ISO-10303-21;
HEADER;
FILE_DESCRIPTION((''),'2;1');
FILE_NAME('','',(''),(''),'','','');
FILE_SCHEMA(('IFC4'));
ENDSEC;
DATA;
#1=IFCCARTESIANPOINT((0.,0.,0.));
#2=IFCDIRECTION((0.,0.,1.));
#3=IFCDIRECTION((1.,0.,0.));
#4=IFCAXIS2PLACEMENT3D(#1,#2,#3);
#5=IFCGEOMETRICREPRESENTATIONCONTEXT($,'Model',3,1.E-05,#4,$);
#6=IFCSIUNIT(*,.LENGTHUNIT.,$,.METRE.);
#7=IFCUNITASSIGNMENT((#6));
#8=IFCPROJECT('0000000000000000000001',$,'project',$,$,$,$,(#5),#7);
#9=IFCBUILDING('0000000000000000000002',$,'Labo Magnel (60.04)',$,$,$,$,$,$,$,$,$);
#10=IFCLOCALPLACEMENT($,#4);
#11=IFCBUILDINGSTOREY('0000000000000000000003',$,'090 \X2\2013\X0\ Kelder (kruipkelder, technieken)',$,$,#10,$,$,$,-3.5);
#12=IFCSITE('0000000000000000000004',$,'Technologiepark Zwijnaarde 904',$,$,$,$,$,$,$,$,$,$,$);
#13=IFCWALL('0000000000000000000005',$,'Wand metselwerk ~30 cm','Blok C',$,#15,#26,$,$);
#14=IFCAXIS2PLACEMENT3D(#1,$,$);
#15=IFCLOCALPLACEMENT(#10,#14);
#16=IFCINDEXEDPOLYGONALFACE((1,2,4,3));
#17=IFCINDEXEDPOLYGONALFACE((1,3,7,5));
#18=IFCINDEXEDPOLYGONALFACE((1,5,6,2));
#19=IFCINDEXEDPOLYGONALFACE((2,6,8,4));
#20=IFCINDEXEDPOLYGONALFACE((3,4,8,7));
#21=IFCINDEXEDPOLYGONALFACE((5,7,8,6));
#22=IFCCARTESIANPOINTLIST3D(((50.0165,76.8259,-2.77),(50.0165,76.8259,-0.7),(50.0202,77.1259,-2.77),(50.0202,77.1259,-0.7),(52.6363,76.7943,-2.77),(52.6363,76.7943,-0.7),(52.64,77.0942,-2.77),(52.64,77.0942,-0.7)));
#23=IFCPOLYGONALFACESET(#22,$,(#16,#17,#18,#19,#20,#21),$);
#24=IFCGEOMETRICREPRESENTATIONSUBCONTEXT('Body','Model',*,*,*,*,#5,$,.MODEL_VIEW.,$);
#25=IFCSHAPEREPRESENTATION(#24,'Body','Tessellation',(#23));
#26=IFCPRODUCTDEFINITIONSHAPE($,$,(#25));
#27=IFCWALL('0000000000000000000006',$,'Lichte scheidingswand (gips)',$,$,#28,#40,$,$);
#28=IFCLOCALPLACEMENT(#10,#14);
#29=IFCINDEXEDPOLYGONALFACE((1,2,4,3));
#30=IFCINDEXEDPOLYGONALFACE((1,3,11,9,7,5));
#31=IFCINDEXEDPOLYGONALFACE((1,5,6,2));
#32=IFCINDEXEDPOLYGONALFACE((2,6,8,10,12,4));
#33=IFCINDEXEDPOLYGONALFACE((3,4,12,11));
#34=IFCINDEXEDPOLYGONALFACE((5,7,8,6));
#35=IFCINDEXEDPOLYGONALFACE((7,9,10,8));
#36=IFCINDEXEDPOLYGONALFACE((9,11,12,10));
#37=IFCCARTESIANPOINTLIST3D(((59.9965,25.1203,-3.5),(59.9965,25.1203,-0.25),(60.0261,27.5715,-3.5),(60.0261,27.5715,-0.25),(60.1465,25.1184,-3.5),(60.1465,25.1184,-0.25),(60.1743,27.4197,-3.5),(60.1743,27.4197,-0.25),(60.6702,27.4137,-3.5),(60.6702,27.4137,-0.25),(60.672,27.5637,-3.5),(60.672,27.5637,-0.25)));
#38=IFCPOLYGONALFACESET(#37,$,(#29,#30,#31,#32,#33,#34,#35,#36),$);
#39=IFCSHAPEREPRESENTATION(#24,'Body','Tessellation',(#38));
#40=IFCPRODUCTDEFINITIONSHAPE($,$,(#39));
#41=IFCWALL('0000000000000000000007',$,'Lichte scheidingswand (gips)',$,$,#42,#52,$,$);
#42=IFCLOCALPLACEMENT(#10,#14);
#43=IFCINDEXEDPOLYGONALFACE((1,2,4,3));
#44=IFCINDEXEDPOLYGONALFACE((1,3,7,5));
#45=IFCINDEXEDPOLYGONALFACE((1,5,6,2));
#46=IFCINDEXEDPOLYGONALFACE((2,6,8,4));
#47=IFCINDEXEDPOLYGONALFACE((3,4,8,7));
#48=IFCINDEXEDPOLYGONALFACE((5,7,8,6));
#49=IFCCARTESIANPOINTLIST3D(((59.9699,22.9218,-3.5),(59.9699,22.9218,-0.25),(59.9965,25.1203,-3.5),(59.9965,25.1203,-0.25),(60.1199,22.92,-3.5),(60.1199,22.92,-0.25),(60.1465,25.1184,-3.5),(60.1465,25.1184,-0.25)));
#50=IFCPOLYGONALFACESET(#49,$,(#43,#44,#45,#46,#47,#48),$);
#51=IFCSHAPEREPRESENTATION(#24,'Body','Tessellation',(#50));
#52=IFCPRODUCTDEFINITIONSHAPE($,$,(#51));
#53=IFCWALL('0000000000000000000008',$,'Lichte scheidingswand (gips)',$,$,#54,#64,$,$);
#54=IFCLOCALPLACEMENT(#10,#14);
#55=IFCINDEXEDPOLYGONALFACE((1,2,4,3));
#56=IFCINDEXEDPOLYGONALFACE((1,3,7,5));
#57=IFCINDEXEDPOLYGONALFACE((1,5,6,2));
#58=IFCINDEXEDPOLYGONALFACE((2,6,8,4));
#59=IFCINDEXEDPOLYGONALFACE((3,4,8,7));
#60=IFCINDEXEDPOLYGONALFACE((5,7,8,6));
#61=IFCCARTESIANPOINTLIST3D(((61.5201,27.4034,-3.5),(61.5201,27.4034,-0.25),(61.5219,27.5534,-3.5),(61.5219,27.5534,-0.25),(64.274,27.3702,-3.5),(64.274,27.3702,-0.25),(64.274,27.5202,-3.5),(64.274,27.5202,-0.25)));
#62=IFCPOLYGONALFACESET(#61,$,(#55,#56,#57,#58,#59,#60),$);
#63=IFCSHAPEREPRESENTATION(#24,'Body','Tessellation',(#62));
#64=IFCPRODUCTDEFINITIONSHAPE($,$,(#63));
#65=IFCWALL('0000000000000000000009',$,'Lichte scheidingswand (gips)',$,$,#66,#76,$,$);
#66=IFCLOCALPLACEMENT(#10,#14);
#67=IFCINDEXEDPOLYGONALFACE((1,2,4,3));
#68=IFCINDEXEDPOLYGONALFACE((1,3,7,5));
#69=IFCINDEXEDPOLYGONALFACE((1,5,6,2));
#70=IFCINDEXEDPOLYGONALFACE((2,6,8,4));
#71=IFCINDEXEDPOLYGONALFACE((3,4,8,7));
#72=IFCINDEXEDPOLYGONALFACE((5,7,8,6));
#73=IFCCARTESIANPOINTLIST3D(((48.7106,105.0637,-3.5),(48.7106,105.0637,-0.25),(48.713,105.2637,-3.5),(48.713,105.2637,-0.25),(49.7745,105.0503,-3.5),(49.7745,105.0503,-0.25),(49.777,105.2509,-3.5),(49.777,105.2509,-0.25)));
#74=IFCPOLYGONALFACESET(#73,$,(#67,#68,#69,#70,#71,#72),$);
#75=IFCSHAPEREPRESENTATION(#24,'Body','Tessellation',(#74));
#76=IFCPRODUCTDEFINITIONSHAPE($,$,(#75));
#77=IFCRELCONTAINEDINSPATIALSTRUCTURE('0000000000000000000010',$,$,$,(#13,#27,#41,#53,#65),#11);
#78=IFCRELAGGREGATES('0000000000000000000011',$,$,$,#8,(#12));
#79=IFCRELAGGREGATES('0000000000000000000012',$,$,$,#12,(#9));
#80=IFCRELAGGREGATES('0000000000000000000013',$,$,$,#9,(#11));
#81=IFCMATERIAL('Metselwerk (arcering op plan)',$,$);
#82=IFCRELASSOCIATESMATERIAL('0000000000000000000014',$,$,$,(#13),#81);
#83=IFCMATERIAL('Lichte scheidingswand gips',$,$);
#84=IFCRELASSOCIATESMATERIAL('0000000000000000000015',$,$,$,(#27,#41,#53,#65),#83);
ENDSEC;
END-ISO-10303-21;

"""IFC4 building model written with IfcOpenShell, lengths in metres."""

from ifc_helpers import new_model, si_unit, frame, origin, origin_with_axes, place, context, subcontext, project, spatial, polyline, outline, extrude, material, element, save


model = new_model("IFC4")

# Units and contexts
model_context = context("Model", 3, precision=1e-05, world=origin_with_axes())
body_context = subcontext(model_context, "Body", "Model", "MODEL_VIEW")
ifc_project = project(units=[si_unit("LENGTHUNIT", "METRE")], contexts=[model_context])

# Site, building, storey
site = spatial("IfcSite", under=ifc_project, Name="Technologiepark Zwijnaarde 904")
building = spatial("IfcBuilding", under=site, Name="Labo Magnel (60.04)")
storey_placement = place(None, origin_with_axes())
storey = spatial("IfcBuildingStorey", under=building, at=storey_placement, Name="090 – Kelder (kruipkelder, technieken)", Elevation=-3.5)

# Shared definitions
ifc_material_1 = material(Name="Metselwerk (arcering op plan)")

# Walls
wall_1_placement = place(storey_placement, frame((0.0, 0.0, -2.77), z_axis=(0.0, 0.0, 1.0), x_axis=(1.0, 0.0, 0.0)))
element("IfcWall", 1, at=wall_1_placement, inside=storey, material=ifc_material_1, Name="Wand metselwerk ~30 cm", Description="Blok C", context=body_context, shape_type="SweptSolid", body=[
    extrude(outline(polyline([(52.64, 77.0942), (50.0202, 77.1259), (50.0165, 76.8259), (52.6363, 76.7943), (52.64, 77.0942)])), origin(), (0.0, 0.0, 1.0), 2.07),
])
ifc_material_2 = material(Name="Lichte scheidingswand gips")
wall_2_placement = place(storey_placement, frame((0.0, 0.0, -3.5), z_axis=(0.0, 0.0, 1.0), x_axis=(1.0, 0.0, 0.0)))
element("IfcWall", 2, at=wall_2_placement, inside=storey, material=ifc_material_2, Name="Lichte scheidingswand (gips)", context=body_context, shape_type="SweptSolid", body=[
    extrude(outline(polyline([(60.672, 27.5637), (60.0261, 27.5715), (59.9965, 25.1203), (60.1465, 25.1184), (60.1743, 27.4197), (60.6702, 27.4137), (60.672, 27.5637)])), origin(), (0.0, 0.0, 1.0), 3.25),
])
wall_3_placement = place(storey_placement, frame((0.0, 0.0, -3.5), z_axis=(0.0, 0.0, 1.0), x_axis=(1.0, 0.0, 0.0)))
element("IfcWall", 3, at=wall_3_placement, inside=storey, material=ifc_material_2, Name="Lichte scheidingswand (gips)", context=body_context, shape_type="SweptSolid", body=[
    extrude(outline(polyline([(59.9965, 25.1203), (60.1465, 25.1184), (60.1199, 22.92), (59.9699, 22.9218), (59.9965, 25.1203)])), origin(), (0.0, 0.0, 1.0), 3.25),
])
wall_4_placement = place(storey_placement, frame((0.0, 0.0, -3.5), z_axis=(0.0, 0.0, 1.0), x_axis=(1.0, 0.0, 0.0)))
element("IfcWall", 4, at=wall_4_placement, inside=storey, material=ifc_material_2, Name="Lichte scheidingswand (gips)", context=body_context, shape_type="SweptSolid", body=[
    extrude(outline(polyline([(61.5201, 27.4034), (64.274, 27.3702), (64.274, 27.5202), (61.5219, 27.5534), (61.5201, 27.4034)])), origin(), (0.0, 0.0, 1.0), 3.25),
])
wall_5_placement = place(storey_placement, frame((0.0, 0.0, -3.5), z_axis=(0.0, 0.0, 1.0), x_axis=(1.0, 0.0, 0.0)))
element("IfcWall", 5, at=wall_5_placement, inside=storey, material=ifc_material_2, Name="Lichte scheidingswand (gips)", context=body_context, shape_type="SweptSolid", body=[
    extrude(outline(polyline([(48.713, 105.2637), (49.777, 105.2509), (49.7745, 105.0503), (48.7106, 105.0637), (48.713, 105.2637)])), origin(), (0.0, 0.0, 1.0), 3.25),
])

save(model, "model.ifc")
